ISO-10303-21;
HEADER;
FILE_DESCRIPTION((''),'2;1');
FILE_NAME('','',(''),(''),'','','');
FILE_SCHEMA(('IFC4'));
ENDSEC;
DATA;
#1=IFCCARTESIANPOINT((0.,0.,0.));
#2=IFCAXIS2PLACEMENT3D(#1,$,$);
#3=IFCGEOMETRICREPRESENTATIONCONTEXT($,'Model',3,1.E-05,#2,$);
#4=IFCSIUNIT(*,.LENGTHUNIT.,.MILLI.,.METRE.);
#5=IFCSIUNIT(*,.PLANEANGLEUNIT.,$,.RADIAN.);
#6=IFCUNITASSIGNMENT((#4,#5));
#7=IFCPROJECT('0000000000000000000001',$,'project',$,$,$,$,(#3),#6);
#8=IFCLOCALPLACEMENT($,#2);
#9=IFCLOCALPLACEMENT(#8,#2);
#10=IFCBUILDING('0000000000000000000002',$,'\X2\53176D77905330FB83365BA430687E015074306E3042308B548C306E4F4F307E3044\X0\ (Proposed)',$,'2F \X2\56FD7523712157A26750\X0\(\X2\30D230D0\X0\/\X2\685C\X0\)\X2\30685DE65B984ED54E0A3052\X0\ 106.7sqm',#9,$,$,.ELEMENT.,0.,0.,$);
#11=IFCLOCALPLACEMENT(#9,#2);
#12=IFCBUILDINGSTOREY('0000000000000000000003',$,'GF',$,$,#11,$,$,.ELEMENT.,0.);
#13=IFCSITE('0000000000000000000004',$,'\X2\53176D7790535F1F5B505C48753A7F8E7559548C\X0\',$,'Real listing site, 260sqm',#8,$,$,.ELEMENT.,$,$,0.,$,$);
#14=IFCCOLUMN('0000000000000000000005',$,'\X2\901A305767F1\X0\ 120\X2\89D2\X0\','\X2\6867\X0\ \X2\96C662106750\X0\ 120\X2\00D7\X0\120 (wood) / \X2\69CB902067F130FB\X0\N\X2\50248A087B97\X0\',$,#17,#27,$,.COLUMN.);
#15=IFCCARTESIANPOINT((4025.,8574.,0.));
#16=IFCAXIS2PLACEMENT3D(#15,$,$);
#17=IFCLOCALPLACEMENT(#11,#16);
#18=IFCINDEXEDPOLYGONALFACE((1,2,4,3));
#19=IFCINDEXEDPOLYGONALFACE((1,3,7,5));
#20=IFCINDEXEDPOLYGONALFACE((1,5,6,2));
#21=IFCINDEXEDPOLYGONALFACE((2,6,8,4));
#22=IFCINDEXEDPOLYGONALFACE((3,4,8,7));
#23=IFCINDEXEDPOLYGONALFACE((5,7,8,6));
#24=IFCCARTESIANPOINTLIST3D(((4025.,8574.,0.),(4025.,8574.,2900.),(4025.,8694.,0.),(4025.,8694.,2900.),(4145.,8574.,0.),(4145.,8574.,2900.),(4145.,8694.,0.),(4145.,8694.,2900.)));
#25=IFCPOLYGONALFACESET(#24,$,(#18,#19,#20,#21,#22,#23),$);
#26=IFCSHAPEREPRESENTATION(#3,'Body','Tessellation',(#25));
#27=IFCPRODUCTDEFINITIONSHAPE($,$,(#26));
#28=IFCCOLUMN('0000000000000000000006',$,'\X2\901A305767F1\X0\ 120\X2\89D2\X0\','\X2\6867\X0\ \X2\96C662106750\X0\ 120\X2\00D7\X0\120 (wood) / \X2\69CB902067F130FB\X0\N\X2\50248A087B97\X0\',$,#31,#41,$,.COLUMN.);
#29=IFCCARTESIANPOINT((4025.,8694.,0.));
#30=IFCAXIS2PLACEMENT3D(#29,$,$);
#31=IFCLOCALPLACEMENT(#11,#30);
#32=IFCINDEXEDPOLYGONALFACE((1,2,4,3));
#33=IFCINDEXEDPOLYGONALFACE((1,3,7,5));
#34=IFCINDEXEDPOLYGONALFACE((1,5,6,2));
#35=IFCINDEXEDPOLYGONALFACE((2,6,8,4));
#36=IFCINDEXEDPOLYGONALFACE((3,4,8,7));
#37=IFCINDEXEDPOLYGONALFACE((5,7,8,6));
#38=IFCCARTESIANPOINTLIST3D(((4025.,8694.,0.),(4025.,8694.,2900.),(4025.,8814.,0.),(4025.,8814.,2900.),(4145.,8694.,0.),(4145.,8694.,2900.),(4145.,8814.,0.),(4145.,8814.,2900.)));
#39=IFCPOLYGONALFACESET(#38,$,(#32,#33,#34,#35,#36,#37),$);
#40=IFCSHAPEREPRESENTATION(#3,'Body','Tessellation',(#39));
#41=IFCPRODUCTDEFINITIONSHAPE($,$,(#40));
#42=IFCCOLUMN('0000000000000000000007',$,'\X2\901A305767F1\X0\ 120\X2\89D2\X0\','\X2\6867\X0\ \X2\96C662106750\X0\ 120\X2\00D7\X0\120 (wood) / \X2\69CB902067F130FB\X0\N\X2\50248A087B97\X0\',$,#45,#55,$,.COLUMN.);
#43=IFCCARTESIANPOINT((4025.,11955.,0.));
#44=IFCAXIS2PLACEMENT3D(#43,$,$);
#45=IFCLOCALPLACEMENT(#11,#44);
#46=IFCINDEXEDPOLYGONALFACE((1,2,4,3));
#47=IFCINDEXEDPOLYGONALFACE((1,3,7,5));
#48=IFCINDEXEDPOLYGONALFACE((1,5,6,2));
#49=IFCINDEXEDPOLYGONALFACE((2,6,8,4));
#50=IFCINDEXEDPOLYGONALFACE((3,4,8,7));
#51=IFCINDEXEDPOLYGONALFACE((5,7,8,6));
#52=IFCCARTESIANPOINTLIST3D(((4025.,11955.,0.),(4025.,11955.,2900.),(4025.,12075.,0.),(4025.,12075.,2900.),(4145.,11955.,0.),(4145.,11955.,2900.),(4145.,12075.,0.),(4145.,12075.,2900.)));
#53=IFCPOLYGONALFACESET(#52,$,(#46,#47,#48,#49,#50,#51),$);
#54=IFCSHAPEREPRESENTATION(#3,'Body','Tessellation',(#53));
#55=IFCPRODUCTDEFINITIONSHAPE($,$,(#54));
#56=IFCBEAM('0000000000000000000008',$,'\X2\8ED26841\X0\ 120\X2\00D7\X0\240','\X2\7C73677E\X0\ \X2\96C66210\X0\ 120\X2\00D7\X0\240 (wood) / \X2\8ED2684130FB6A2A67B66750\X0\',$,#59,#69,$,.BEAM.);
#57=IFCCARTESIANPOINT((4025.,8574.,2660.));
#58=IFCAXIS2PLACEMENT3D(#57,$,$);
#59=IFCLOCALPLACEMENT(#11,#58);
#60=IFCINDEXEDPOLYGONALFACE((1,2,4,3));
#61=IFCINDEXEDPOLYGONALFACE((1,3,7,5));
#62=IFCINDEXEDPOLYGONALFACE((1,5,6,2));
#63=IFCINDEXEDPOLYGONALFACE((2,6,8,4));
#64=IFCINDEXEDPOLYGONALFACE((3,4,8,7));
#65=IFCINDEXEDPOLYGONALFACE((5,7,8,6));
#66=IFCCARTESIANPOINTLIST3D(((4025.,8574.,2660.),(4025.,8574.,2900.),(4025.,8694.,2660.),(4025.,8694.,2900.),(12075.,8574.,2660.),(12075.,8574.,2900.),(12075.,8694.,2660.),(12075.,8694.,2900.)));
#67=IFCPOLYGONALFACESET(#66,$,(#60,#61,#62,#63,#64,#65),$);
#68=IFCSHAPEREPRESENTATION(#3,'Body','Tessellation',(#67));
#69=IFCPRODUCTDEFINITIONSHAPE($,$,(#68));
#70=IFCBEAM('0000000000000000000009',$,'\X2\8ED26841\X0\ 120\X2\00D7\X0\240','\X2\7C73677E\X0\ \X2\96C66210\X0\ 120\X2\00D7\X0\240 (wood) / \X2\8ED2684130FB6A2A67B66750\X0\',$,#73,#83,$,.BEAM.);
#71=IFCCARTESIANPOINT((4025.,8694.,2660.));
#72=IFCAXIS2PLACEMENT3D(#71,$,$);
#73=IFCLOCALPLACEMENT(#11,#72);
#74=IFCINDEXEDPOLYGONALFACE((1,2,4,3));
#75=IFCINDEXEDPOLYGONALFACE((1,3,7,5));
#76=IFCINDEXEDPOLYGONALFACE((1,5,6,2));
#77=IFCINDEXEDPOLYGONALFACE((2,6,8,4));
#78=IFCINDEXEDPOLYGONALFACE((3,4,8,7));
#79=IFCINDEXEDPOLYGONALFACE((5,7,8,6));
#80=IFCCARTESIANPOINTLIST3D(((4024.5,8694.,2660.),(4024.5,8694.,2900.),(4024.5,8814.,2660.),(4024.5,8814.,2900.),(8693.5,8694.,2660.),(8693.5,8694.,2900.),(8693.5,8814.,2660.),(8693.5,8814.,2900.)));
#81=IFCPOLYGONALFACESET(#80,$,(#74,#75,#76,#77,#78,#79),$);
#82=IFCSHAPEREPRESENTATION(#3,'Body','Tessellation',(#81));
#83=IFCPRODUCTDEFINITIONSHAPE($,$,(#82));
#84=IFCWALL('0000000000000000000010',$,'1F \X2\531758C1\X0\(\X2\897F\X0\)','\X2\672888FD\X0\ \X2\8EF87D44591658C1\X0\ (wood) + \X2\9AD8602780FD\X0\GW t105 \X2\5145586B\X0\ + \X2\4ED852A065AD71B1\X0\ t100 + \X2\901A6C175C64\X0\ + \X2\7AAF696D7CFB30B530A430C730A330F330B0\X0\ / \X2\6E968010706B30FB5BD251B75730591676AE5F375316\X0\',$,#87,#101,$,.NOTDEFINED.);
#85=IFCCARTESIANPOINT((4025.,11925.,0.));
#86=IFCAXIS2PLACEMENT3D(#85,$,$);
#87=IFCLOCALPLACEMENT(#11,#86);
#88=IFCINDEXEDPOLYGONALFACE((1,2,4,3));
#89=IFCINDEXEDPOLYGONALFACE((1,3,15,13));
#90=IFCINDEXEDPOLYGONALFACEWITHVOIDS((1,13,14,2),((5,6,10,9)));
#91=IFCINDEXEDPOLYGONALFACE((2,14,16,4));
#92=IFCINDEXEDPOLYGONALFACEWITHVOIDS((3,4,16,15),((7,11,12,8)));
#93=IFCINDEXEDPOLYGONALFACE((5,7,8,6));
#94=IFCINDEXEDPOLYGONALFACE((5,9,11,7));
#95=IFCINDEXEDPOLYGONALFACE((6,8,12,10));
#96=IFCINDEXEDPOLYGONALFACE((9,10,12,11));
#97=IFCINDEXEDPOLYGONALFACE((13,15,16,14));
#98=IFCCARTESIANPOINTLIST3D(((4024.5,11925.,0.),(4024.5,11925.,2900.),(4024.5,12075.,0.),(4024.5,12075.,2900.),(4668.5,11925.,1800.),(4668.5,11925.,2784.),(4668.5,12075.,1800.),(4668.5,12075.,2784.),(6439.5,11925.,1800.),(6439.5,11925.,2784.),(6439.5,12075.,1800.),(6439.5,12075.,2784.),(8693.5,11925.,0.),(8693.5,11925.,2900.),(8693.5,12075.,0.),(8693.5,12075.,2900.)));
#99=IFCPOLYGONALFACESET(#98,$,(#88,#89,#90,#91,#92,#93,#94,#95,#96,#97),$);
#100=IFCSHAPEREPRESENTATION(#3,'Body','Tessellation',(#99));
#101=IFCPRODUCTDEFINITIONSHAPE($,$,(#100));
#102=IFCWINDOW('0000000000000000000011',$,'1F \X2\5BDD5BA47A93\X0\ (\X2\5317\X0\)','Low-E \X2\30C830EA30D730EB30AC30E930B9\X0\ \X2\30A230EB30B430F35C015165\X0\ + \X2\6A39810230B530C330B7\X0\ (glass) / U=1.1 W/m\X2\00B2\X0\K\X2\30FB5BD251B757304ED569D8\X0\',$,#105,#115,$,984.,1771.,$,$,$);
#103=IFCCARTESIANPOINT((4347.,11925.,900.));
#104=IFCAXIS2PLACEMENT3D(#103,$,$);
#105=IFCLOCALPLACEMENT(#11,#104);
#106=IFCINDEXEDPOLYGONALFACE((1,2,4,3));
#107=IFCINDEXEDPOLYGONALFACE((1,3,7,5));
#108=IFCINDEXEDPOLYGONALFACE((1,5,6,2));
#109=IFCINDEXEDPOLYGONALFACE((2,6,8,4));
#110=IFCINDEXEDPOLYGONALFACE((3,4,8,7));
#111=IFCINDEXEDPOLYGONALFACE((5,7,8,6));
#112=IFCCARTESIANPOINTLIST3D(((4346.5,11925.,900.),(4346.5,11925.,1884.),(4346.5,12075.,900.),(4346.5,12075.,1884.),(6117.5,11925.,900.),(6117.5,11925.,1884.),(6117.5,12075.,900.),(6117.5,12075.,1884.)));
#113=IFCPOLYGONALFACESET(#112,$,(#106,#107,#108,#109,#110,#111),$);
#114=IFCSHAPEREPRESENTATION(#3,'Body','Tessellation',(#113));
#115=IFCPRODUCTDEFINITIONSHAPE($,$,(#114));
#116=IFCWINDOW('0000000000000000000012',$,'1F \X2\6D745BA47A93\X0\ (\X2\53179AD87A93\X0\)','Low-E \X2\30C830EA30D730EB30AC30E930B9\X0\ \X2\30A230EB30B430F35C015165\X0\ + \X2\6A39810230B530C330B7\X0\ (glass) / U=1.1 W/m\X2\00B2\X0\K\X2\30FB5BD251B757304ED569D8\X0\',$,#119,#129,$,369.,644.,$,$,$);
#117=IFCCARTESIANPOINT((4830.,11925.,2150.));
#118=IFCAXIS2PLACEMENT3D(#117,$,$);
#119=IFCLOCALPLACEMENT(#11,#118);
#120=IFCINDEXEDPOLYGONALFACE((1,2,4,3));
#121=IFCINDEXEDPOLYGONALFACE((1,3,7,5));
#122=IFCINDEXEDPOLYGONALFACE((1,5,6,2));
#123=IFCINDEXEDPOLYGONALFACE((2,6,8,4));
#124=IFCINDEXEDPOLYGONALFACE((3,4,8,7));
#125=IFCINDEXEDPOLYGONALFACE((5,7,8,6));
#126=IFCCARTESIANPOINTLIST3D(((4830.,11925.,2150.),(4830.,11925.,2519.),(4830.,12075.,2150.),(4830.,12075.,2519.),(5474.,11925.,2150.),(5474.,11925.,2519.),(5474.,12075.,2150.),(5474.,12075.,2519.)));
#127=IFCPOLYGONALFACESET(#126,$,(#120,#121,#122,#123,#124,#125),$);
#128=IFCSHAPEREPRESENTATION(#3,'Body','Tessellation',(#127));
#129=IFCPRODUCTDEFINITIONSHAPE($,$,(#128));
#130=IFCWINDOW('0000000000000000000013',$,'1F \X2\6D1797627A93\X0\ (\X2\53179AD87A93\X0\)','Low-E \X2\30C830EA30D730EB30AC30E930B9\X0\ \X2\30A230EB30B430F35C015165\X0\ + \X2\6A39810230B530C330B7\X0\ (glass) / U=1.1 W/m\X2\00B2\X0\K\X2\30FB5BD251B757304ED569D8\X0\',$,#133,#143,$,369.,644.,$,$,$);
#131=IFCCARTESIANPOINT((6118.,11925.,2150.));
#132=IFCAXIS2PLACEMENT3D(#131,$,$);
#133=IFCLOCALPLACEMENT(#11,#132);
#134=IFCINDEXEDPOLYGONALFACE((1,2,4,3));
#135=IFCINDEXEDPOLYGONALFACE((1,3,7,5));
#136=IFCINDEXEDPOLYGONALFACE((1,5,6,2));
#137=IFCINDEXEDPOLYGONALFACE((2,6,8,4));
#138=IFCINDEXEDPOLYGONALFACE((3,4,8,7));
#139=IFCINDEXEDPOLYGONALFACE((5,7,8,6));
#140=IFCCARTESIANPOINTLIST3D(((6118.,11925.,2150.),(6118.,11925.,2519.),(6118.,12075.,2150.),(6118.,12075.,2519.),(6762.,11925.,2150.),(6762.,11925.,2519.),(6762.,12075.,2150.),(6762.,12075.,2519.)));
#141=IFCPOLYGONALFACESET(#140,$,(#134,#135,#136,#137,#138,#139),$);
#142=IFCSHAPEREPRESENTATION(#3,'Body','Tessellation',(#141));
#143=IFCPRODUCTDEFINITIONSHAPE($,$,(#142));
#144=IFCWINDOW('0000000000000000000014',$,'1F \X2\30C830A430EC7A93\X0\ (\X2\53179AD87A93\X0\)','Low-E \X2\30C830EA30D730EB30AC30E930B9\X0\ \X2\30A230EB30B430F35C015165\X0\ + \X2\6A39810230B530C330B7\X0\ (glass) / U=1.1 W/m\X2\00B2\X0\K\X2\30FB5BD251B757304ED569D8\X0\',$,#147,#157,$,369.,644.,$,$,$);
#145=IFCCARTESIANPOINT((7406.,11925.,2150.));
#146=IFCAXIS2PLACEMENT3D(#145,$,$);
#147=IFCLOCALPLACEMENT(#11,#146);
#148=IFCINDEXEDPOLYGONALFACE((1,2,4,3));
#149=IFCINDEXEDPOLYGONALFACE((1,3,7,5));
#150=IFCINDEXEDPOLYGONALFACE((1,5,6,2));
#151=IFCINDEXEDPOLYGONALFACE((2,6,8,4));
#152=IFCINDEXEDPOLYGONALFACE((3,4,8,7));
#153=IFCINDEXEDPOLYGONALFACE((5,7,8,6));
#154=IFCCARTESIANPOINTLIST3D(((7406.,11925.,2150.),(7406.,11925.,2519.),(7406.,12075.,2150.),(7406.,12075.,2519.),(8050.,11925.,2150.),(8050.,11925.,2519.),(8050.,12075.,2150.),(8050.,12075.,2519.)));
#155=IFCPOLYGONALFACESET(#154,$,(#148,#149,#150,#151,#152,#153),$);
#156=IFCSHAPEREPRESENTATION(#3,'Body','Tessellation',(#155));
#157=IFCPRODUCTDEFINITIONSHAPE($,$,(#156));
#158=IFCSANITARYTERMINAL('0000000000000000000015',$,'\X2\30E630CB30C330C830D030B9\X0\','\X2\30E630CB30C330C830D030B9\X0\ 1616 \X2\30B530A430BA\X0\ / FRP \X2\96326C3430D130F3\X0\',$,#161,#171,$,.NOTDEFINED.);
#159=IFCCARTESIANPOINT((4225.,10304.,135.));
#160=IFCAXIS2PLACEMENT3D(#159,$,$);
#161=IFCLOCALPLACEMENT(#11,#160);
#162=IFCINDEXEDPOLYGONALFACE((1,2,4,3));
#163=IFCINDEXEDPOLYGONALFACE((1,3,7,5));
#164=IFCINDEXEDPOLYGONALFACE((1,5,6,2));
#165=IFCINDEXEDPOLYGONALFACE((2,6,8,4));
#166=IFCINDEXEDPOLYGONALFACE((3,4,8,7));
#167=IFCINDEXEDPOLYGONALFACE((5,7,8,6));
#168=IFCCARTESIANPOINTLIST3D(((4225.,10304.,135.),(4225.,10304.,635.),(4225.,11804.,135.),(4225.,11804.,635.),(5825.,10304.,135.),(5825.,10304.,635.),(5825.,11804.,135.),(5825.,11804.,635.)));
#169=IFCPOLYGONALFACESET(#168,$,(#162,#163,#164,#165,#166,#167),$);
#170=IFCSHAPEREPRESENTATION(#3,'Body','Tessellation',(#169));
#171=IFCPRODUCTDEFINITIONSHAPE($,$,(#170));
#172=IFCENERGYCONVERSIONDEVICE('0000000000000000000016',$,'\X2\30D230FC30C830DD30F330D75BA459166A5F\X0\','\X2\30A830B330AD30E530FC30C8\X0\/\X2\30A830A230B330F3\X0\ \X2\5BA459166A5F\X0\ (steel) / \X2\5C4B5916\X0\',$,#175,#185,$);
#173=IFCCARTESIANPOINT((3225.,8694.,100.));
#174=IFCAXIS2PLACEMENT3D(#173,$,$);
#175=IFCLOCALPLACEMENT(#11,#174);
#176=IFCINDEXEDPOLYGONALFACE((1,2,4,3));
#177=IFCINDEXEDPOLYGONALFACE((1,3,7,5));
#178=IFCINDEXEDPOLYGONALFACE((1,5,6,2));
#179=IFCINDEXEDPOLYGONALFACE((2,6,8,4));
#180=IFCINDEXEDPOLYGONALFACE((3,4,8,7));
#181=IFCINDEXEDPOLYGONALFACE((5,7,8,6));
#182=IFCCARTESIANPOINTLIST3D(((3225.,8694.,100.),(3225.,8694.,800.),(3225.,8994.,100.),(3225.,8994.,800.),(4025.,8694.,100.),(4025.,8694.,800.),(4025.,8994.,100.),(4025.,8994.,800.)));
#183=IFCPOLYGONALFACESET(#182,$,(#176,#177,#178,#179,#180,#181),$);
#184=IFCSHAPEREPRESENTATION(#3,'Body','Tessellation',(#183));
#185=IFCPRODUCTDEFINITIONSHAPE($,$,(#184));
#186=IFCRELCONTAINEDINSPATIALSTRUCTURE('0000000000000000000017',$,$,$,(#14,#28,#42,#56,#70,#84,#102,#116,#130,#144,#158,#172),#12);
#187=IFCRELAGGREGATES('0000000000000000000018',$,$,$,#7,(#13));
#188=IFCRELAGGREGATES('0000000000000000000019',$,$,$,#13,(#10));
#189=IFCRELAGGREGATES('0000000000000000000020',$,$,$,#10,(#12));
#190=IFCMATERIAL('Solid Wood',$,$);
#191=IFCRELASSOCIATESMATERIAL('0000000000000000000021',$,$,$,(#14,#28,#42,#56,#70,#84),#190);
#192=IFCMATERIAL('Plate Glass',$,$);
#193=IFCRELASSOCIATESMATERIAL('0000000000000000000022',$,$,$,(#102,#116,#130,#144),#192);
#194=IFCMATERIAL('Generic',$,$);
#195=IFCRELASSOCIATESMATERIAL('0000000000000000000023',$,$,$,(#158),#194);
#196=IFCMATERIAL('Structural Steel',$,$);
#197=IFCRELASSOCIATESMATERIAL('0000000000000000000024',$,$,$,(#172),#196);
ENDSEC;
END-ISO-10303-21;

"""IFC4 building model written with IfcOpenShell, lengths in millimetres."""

from ifc_helpers import new_model, si_unit, frame, frame_2d, origin, place, context, project, spatial, rectangle, extrude, material, element, fill, save


model = new_model("IFC4")

# Units and contexts
model_context = context("Model", 3, precision=1e-05, world=origin())
ifc_project = project(units=[si_unit("LENGTHUNIT", "METRE", prefix="MILLI"), si_unit("PLANEANGLEUNIT", "RADIAN")], contexts=[model_context])

# Site, building, storey
site_placement = place(None, origin())
site = spatial("IfcSite", under=ifc_project, at=site_placement, Name="北海道弟子屈町美留和", ObjectType="Real listing site, 260sqm", CompositionType="ELEMENT", RefElevation=0.0)
building_placement = place(site_placement, origin())
building = spatial("IfcBuilding", under=site, at=building_placement, Name="北海道・茶室と縁側のある和の住まい (Proposed)", ObjectType="2F 国産無垢材(ヒバ/桜)と左官仕上げ 106.7sqm", CompositionType="ELEMENT", ElevationOfRefHeight=0.0, ElevationOfTerrain=0.0)
storey_placement = place(building_placement, origin())
storey = spatial("IfcBuildingStorey", under=building, at=storey_placement, Name="GF", CompositionType="ELEMENT", Elevation=0.0)

# Columns
ifc_material_1 = material(Name="Solid Wood")
column_1_placement = place(storey_placement, frame((4025.0, 8574.0, 0.0)))
element("IfcColumn", 1, at=column_1_placement, inside=storey, material=ifc_material_1, Name="通し柱 120角", Description="桧 集成材 120×120 (wood) / 構造柱・N値計算", PredefinedType="COLUMN", context=model_context, shape_type="SweptSolid", body=[
    extrude(rectangle(XDim=120.0, YDim=120.0, at=frame_2d((60.0, 60.0))), frame((4025.0, 8574.0, 0.0)), (0.0, 0.0, 1.0), 2900.0),
])
column_2_placement = place(storey_placement, frame((4025.0, 8694.0, 0.0)))
element("IfcColumn", 2, at=column_2_placement, inside=storey, material=ifc_material_1, Name="通し柱 120角", Description="桧 集成材 120×120 (wood) / 構造柱・N値計算", PredefinedType="COLUMN", context=model_context, shape_type="SweptSolid", body=[
    extrude(rectangle(XDim=120.0, YDim=120.0, at=frame_2d((60.0, 60.0))), frame((4025.0, 8694.0, 0.0)), (0.0, 0.0, 1.0), 2900.0),
])
column_3_placement = place(storey_placement, frame((4025.0, 11955.0, 0.0)))
element("IfcColumn", 3, at=column_3_placement, inside=storey, material=ifc_material_1, Name="通し柱 120角", Description="桧 集成材 120×120 (wood) / 構造柱・N値計算", PredefinedType="COLUMN", context=model_context, shape_type="SweptSolid", body=[
    extrude(rectangle(XDim=120.0, YDim=120.0, at=frame_2d((60.0, 60.0))), frame((4025.0, 11955.0, 0.0)), (0.0, 0.0, 1.0), 2900.0),
])

# Beams
beam_1_placement = place(storey_placement, frame((4025.0, 8574.0, 2660.0)))
element("IfcBeam", 4, at=beam_1_placement, inside=storey, material=ifc_material_1, Name="軒桁 120×240", Description="米松 集成 120×240 (wood) / 軒桁・横架材", PredefinedType="BEAM", context=model_context, shape_type="SweptSolid", body=[
    extrude(rectangle(XDim=8050.0, YDim=120.0, at=frame_2d((4025.0, 60.0))), frame((4025.0, 8574.0, 2660.0)), (0.0, 0.0, 1.0), 240.0),
])
beam_2_placement = place(storey_placement, frame((4025.0, 8694.0, 2660.0)))
element("IfcBeam", 5, at=beam_2_placement, inside=storey, material=ifc_material_1, Name="軒桁 120×240", Description="米松 集成 120×240 (wood) / 軒桁・横架材", PredefinedType="BEAM", context=model_context, shape_type="SweptSolid", body=[
    extrude(rectangle(XDim=4669.0, YDim=120.0, at=frame_2d((2334.0, 60.0))), frame((4025.0, 8694.0, 2660.0)), (0.0, 0.0, 1.0), 240.0),
])

# Wall, openings, windows
wall_1_placement = place(storey_placement, frame((4025.0, 11925.0, 0.0)))
wall_1 = element("IfcWall", 6, at=wall_1_placement, inside=storey, material=ifc_material_1, Name="1F 北壁(西)", Description="木製 軸組外壁 (wood) + 高性能GW t105 充填 + 付加断熱 t100 + 通気層 + 窯業系サイディング / 準耐火・寒冷地外皮強化", PredefinedType="NOTDEFINED", context=model_context, shape_type="SweptSolid", body=[
    extrude(rectangle(XDim=4669.0, YDim=150.0, at=frame_2d((2334.0, 75.0))), frame((4025.0, 11925.0, 0.0)), (0.0, 0.0, 1.0), 2900.0),
])
opening_1_placement = place(storey_placement, frame((4347.0, 11925.0, 900.0)))
opening_1 = element("IfcOpeningElement", 7, at=opening_1_placement, cuts=wall_1, PredefinedType="NOTDEFINED", context=model_context, shape_type="SweptSolid", body=[
    extrude(rectangle(XDim=1771.0, YDim=150.0, at=frame_2d((885.0, 75.0))), frame((4347.0, 11925.0, 900.0)), (0.0, 0.0, 1.0), 984.0),
])
opening_2_placement = place(storey_placement, frame((4830.0, 11925.0, 2150.0)))
opening_2 = element("IfcOpeningElement", 8, at=opening_2_placement, cuts=wall_1, PredefinedType="NOTDEFINED", context=model_context, shape_type="SweptSolid", body=[
    extrude(rectangle(XDim=644.0, YDim=150.0, at=frame_2d((322.0, 75.0))), frame((4830.0, 11925.0, 2150.0)), (0.0, 0.0, 1.0), 369.0),
])
opening_3_placement = place(storey_placement, frame((6118.0, 11925.0, 2150.0)))
opening_3 = element("IfcOpeningElement", 9, at=opening_3_placement, cuts=wall_1, PredefinedType="NOTDEFINED", context=model_context, shape_type="SweptSolid", body=[
    extrude(rectangle(XDim=644.0, YDim=150.0, at=frame_2d((322.0, 75.0))), frame((6118.0, 11925.0, 2150.0)), (0.0, 0.0, 1.0), 369.0),
])
opening_4_placement = place(storey_placement, frame((7406.0, 11925.0, 2150.0)))
opening_4 = element("IfcOpeningElement", 10, at=opening_4_placement, cuts=wall_1, PredefinedType="NOTDEFINED", context=model_context, shape_type="SweptSolid", body=[
    extrude(rectangle(XDim=644.0, YDim=150.0, at=frame_2d((322.0, 75.0))), frame((7406.0, 11925.0, 2150.0)), (0.0, 0.0, 1.0), 369.0),
])
ifc_material_2 = material(Name="Plate Glass")
window_1_placement = place(storey_placement, frame((4347.0, 11925.0, 900.0)))
window_1 = element("IfcWindow", 11, at=window_1_placement, inside=storey, material=ifc_material_2, Name="1F 寝室窓 (北)", Description="Low-E トリプルガラス アルゴン封入 + 樹脂サッシ (glass) / U=1.1 W/m²K・寒冷地仕様", OverallHeight=984.0, OverallWidth=1771.0, context=model_context, shape_type="SweptSolid", body=[
    extrude(rectangle(XDim=1771.0, YDim=150.0, at=frame_2d((885.0, 75.0))), frame((4347.0, 11925.0, 900.0)), (0.0, 0.0, 1.0), 984.0),
])
fill(opening_1, window_1)
window_2_placement = place(storey_placement, frame((4830.0, 11925.0, 2150.0)))
window_2 = element("IfcWindow", 12, at=window_2_placement, inside=storey, material=ifc_material_2, Name="1F 浴室窓 (北高窓)", Description="Low-E トリプルガラス アルゴン封入 + 樹脂サッシ (glass) / U=1.1 W/m²K・寒冷地仕様", OverallHeight=369.0, OverallWidth=644.0, context=model_context, shape_type="SweptSolid", body=[
    extrude(rectangle(XDim=644.0, YDim=150.0, at=frame_2d((322.0, 75.0))), frame((4830.0, 11925.0, 2150.0)), (0.0, 0.0, 1.0), 369.0),
])
fill(opening_2, window_2)
window_3_placement = place(storey_placement, frame((6118.0, 11925.0, 2150.0)))
window_3 = element("IfcWindow", 13, at=window_3_placement, inside=storey, material=ifc_material_2, Name="1F 洗面窓 (北高窓)", Description="Low-E トリプルガラス アルゴン封入 + 樹脂サッシ (glass) / U=1.1 W/m²K・寒冷地仕様", OverallHeight=369.0, OverallWidth=644.0, context=model_context, shape_type="SweptSolid", body=[
    extrude(rectangle(XDim=644.0, YDim=150.0, at=frame_2d((322.0, 75.0))), frame((6118.0, 11925.0, 2150.0)), (0.0, 0.0, 1.0), 369.0),
])
fill(opening_3, window_3)
window_4_placement = place(storey_placement, frame((7406.0, 11925.0, 2150.0)))
window_4 = element("IfcWindow", 14, at=window_4_placement, inside=storey, material=ifc_material_2, Name="1F トイレ窓 (北高窓)", Description="Low-E トリプルガラス アルゴン封入 + 樹脂サッシ (glass) / U=1.1 W/m²K・寒冷地仕様", OverallHeight=369.0, OverallWidth=644.0, context=model_context, shape_type="SweptSolid", body=[
    extrude(rectangle(XDim=644.0, YDim=150.0, at=frame_2d((322.0, 75.0))), frame((7406.0, 11925.0, 2150.0)), (0.0, 0.0, 1.0), 369.0),
])
fill(opening_4, window_4)

# Shared definitions
ifc_material_3 = material(Name="Generic")

# Sanitary terminal
sanitary_terminal_placement = place(storey_placement, frame((4225.0, 10304.0, 135.0)))
element("IfcSanitaryTerminal", 15, at=sanitary_terminal_placement, inside=storey, material=ifc_material_3, Name="ユニットバス", Description="ユニットバス 1616 サイズ / FRP 防水パン", PredefinedType="NOTDEFINED", context=model_context, shape_type="SweptSolid", body=[
    extrude(rectangle(XDim=1600.0, YDim=1500.0, at=frame_2d((800.0, 750.0))), frame((4225.0, 10304.0, 135.0)), (0.0, 0.0, 1.0), 500.0),
])

# Energy conversion device
ifc_material_4 = material(Name="Structural Steel")
energy_conversion_device_placement = place(storey_placement, frame((3225.0, 8694.0, 100.0)))
element("IfcEnergyConversionDevice", 16, at=energy_conversion_device_placement, inside=storey, material=ifc_material_4, Name="ヒートポンプ室外機", Description="エコキュート/エアコン 室外機 (steel) / 屋外", context=model_context, shape_type="SweptSolid", body=[
    extrude(rectangle(XDim=800.0, YDim=300.0, at=frame_2d((400.0, 150.0))), frame((3225.0, 8694.0, 100.0)), (0.0, 0.0, 1.0), 700.0),
])

save(model, "model.ifc")
